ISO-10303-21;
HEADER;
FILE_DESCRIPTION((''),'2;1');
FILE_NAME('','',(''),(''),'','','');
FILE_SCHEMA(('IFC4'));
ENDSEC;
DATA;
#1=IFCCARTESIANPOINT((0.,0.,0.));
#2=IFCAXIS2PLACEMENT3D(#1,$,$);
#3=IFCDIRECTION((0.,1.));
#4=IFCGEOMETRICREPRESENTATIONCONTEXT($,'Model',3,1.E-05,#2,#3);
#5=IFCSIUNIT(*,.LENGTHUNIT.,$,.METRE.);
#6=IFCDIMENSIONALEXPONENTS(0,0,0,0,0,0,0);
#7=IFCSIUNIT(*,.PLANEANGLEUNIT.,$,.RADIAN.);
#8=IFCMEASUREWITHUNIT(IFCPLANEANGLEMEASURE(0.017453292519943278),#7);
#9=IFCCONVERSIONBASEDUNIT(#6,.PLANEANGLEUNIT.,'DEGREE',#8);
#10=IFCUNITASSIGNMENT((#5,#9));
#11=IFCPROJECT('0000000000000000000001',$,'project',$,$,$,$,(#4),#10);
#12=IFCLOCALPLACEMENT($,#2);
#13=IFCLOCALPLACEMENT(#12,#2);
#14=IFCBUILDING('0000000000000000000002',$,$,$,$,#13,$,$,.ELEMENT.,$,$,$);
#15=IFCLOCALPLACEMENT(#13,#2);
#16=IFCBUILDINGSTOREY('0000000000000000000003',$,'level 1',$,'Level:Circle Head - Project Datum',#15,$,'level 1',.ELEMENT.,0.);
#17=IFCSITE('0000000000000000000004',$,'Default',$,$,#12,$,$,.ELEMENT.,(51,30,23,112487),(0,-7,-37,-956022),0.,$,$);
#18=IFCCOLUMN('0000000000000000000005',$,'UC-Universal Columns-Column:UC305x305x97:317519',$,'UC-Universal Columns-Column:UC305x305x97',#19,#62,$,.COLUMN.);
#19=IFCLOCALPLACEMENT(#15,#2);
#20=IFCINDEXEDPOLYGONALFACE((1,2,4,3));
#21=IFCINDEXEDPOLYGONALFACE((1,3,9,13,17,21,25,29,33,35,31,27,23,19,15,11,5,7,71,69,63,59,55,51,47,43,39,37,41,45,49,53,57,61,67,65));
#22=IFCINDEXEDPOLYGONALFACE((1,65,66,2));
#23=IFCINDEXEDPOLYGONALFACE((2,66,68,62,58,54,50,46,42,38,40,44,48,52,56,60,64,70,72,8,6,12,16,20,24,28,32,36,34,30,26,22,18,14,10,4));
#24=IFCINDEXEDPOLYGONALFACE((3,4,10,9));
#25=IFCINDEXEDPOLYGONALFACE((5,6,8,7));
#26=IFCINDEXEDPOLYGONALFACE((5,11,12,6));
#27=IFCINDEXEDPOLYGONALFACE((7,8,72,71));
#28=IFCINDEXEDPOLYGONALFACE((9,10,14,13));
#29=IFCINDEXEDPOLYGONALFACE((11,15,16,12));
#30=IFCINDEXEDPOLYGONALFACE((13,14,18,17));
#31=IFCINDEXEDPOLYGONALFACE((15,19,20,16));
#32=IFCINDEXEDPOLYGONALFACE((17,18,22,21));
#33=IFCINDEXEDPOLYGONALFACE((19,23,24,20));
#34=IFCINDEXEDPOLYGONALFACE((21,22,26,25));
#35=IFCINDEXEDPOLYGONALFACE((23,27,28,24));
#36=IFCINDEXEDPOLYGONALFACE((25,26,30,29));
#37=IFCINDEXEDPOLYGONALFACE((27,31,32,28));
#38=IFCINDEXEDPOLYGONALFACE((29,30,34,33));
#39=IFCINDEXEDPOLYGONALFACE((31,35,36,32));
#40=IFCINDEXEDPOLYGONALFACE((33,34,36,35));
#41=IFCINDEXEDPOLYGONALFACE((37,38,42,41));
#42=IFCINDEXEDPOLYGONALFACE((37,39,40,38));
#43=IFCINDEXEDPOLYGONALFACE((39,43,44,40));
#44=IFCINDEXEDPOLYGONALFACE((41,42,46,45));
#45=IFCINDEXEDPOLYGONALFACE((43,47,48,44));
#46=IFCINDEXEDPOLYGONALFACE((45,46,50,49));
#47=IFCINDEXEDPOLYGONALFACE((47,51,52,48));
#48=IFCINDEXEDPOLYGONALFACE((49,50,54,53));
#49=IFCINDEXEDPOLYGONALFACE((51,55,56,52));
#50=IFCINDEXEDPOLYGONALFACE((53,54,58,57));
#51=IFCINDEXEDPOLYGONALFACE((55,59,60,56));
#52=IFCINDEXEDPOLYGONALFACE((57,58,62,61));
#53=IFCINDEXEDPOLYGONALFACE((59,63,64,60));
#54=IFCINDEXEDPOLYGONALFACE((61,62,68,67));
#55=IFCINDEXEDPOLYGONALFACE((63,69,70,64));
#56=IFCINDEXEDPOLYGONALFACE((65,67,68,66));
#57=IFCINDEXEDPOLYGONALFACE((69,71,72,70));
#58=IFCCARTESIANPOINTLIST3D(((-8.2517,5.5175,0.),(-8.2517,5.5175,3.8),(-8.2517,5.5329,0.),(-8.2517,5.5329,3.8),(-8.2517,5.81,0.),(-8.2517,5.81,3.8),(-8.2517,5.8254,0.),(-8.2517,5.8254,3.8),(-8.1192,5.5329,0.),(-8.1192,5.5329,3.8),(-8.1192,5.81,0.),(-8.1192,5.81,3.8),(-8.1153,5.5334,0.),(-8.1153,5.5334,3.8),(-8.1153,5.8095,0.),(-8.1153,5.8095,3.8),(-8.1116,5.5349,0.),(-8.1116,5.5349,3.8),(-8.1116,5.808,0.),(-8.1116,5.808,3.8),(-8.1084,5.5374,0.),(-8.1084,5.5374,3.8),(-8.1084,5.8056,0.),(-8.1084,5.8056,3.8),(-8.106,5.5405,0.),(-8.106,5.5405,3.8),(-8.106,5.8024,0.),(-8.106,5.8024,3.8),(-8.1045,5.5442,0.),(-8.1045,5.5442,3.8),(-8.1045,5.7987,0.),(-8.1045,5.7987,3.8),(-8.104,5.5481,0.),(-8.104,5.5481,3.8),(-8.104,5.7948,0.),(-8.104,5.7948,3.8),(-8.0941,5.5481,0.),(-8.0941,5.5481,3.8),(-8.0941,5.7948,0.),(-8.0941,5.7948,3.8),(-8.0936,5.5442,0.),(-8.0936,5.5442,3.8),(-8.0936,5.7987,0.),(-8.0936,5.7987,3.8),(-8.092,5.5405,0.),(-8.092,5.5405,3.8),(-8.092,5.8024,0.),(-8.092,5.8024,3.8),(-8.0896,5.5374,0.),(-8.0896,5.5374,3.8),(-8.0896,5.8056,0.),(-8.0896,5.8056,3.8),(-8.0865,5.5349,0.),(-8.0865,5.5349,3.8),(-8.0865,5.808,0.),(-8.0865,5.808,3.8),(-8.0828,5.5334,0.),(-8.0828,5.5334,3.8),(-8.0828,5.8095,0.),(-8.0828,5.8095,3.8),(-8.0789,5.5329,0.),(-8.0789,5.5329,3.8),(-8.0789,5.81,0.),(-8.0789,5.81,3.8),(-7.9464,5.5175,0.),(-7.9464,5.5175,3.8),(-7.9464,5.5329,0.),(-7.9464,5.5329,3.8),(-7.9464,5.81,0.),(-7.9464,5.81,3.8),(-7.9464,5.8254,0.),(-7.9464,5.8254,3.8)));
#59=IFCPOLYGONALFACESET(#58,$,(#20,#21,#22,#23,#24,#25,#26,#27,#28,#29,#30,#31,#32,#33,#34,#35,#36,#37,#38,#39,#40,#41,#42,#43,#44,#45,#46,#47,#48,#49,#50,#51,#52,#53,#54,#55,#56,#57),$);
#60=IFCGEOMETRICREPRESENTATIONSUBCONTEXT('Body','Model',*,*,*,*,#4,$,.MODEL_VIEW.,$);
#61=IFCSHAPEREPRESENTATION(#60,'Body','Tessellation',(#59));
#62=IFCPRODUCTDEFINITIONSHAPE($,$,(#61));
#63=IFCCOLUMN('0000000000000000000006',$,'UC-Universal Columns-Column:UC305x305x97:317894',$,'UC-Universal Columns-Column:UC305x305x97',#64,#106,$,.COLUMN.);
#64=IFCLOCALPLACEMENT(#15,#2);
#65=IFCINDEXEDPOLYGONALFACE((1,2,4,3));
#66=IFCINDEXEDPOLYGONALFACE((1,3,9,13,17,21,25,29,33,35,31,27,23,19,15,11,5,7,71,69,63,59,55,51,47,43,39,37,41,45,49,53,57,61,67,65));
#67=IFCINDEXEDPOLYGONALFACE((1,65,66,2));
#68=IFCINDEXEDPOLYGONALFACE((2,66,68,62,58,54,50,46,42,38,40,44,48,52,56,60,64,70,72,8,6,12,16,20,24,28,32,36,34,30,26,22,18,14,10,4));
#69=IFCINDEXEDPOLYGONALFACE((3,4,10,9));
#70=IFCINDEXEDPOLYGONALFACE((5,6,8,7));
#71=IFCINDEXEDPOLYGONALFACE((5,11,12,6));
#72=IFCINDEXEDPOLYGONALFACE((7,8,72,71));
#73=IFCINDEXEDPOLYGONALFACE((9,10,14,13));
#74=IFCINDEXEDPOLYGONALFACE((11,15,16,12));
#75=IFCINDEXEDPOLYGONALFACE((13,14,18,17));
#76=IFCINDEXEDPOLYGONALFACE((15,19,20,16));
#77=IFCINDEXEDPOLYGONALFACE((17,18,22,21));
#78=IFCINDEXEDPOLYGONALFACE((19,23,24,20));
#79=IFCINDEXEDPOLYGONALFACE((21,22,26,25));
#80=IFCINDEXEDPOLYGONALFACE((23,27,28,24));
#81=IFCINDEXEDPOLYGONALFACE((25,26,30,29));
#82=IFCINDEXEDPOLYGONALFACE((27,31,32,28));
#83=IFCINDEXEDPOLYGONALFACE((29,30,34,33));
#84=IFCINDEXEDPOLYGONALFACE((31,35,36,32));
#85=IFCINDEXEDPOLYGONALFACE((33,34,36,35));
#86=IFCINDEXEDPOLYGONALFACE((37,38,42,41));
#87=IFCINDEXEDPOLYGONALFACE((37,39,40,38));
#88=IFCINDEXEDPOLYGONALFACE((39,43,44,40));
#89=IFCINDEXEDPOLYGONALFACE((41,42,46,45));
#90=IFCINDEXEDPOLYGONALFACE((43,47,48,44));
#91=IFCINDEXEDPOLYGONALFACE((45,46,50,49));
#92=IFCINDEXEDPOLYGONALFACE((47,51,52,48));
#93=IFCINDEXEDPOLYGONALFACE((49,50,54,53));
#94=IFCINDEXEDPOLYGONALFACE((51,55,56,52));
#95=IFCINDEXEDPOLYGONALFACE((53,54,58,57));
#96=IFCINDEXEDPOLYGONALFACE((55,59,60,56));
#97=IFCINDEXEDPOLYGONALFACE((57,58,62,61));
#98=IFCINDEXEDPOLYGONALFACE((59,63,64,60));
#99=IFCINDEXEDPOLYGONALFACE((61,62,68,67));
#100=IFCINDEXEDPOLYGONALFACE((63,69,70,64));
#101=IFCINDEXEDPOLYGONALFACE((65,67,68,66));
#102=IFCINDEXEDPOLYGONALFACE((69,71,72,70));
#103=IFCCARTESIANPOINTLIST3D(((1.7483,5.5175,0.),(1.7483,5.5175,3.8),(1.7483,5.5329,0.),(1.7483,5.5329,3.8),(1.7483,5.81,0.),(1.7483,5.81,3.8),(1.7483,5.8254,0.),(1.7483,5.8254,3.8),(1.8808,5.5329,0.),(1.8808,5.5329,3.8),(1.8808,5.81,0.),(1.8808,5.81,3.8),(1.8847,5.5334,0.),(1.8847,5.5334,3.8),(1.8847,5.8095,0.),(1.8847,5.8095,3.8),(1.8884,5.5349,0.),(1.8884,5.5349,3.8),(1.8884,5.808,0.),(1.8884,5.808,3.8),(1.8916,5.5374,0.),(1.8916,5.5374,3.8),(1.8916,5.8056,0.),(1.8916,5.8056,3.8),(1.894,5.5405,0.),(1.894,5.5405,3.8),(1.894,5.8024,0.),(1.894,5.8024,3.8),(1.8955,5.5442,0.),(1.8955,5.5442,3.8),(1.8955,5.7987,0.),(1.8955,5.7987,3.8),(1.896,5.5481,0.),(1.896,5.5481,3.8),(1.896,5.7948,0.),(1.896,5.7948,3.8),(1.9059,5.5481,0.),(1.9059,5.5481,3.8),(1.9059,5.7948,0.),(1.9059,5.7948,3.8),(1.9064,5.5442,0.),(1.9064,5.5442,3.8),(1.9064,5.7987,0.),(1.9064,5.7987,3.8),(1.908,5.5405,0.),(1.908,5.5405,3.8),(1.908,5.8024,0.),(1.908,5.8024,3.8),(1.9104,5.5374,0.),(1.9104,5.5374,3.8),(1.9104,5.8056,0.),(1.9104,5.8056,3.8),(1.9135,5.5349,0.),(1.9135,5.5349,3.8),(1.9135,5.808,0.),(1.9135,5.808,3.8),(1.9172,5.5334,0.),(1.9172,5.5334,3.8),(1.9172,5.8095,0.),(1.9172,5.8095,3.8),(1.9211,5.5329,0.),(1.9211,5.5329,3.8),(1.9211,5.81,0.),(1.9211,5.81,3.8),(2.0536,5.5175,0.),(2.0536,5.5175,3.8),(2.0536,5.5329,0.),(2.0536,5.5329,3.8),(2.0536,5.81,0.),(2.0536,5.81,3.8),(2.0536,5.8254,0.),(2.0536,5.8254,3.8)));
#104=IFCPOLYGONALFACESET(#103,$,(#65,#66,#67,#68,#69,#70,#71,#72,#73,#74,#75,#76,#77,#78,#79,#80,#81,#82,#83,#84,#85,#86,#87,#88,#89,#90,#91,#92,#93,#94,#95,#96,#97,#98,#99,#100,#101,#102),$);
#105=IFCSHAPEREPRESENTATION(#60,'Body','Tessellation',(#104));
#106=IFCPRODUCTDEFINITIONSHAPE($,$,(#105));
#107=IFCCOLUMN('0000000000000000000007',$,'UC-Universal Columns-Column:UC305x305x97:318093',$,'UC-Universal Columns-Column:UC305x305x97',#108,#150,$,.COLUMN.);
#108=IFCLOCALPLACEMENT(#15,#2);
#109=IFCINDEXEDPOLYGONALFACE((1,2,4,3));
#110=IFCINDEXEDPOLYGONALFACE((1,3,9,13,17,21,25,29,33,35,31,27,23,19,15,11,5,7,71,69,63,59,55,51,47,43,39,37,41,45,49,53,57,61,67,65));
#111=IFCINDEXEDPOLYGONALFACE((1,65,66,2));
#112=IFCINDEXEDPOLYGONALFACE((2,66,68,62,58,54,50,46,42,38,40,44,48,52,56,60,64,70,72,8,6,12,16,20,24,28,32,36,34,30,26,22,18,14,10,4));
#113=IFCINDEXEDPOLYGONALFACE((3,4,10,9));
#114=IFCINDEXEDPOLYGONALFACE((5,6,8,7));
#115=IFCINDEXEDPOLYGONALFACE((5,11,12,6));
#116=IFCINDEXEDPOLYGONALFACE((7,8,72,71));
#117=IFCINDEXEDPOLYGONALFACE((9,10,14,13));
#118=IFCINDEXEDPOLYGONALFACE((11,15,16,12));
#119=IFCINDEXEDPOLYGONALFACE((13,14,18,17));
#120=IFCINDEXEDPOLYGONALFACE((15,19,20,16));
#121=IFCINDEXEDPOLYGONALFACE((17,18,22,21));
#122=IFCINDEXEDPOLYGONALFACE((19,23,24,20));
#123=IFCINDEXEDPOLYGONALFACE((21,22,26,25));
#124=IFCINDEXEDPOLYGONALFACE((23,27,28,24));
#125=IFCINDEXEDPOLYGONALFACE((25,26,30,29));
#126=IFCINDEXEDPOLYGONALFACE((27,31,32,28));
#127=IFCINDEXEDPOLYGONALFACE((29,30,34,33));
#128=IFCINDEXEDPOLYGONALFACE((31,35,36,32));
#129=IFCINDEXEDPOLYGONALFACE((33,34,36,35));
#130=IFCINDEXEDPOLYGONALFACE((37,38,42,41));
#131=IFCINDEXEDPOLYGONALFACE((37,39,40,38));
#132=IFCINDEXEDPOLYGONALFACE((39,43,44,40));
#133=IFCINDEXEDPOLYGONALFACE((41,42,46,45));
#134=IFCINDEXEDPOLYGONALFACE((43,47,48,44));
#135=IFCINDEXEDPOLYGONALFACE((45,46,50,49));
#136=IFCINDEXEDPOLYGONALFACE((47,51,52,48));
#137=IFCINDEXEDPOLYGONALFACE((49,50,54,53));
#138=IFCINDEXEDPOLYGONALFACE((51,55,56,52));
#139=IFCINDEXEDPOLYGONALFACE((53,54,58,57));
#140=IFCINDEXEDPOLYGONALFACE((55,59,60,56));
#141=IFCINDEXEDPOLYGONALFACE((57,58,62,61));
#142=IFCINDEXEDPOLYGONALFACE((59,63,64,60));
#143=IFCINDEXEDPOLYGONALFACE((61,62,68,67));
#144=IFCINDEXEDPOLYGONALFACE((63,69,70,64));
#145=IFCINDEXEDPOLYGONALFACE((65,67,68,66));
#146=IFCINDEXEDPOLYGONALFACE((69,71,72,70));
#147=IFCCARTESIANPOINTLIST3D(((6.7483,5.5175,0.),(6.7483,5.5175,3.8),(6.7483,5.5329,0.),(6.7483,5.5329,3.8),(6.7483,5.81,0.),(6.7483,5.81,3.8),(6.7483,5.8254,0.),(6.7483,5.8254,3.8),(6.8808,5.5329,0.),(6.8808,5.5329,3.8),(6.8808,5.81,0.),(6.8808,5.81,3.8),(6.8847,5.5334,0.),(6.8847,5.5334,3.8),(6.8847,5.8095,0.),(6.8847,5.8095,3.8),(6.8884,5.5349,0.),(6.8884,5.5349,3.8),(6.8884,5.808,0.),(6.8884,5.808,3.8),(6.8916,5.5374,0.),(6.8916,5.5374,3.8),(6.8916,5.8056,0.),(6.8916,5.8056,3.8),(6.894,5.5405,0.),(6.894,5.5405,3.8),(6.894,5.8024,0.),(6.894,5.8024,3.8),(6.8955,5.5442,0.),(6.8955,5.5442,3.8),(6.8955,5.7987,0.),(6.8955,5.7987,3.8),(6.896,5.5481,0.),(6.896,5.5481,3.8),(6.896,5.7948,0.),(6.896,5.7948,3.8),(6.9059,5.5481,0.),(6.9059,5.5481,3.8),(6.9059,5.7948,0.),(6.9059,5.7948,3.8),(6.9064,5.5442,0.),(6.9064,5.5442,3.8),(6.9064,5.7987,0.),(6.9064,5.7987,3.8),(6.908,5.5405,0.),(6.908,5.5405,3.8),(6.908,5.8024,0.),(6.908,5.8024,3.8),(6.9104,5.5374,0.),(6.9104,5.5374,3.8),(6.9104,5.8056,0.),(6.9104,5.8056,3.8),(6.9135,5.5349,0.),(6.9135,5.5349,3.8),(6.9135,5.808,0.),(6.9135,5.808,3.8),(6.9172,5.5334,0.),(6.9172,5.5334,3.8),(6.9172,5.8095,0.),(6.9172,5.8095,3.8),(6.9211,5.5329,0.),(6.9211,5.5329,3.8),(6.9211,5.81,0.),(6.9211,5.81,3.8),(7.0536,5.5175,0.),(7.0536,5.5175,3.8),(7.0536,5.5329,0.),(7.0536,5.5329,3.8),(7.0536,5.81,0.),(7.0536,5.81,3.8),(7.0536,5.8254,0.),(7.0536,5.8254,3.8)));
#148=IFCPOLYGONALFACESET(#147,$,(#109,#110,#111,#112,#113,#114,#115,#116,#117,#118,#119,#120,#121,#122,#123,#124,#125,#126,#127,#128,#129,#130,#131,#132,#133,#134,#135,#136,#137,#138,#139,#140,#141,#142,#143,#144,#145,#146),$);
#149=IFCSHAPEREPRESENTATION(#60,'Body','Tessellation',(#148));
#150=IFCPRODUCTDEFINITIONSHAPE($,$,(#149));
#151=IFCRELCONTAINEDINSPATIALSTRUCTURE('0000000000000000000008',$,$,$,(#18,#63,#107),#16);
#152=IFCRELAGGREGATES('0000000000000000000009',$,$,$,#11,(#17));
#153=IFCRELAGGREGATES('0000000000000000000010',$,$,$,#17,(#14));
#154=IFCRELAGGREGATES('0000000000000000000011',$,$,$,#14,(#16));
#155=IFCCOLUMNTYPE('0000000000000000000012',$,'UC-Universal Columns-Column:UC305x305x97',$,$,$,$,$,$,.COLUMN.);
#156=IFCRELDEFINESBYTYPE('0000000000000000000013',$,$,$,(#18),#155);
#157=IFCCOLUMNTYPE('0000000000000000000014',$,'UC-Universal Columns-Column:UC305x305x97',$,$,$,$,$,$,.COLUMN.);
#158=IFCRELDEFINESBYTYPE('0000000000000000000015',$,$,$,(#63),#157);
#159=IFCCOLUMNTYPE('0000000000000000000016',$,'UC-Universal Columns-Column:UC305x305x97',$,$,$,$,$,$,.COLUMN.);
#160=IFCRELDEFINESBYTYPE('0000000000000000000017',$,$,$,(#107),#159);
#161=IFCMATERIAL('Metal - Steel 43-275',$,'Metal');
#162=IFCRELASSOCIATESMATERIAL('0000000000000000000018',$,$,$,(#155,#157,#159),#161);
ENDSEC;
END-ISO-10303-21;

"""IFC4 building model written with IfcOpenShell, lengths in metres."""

from ifc_helpers import new_model, entity, si_unit, converted_unit, direction, frame, frame_2d, origin, place, context, subcontext, project, spatial, i_section, extrude, source, transform, mapped, material, material_profile, profile_set, type_object, type_shapes, element, save


model = new_model("IFC4")

# Units and contexts
model_context = context("Model", 3, precision=1e-05, world=origin(), true_north=direction((0.0, 1.0)))
body_context = subcontext(model_context, "Body", "Model", "MODEL_VIEW")
ifc_project = project(units=[si_unit("LENGTHUNIT", "METRE"), converted_unit("PLANEANGLEUNIT", "DEGREE", entity("IfcPlaneAngleMeasure", 0.017453292519943278), si_unit("PLANEANGLEUNIT", "RADIAN"), dimensions=[0, 0, 0, 0, 0, 0, 0])], contexts=[model_context])

# Site, building, storey
site_placement = place(None, origin())
site = spatial("IfcSite", under=ifc_project, at=site_placement, Name="Default", CompositionType="ELEMENT", RefLatitude=(51, 30, 23, 112487), RefLongitude=(0, -7, -37, -956022), RefElevation=0.0)
building_placement = place(site_placement, origin())
building = spatial("IfcBuilding", under=site, at=building_placement, CompositionType="ELEMENT")
storey_placement = place(building_placement, origin())
storey = spatial("IfcBuildingStorey", under=building, at=storey_placement, Name="level 1", ObjectType="Level:Circle Head - Project Datum", LongName="level 1", CompositionType="ELEMENT", Elevation=0.0)

# Columns
ifc_material_1 = material(Name="Metal - Steel 43-275", Category="Metal")
ifc_material_profile = material_profile(ifc_material_1, i_section(OverallWidth=0.3053, OverallDepth=0.3079, WebThickness=0.0099, FlangeThickness=0.0154, FilletRadius=0.0152, at=frame_2d((0.0, 0.0), x_axis=(1.0, 0.0))), Name="UC305x305x97")
ifc_profile_set = profile_set([ifc_material_profile], Name="UC305x305x97")
column_type_1 = type_object("IfcColumnType", Name="UC-Universal Columns-Column:UC305x305x97", PredefinedType="COLUMN", material=ifc_profile_set)
shared_shape_1 = source(origin(), body_context, "Body", "SweptSolid", [
    extrude(i_section(OverallWidth=0.3053, OverallDepth=0.3079, WebThickness=0.0099, FlangeThickness=0.0154, FilletRadius=0.0152, at=frame_2d((0.0, 0.0), x_axis=(1.0, 0.0))), frame((-8.099, 5.6715, 0.0), z_axis=(0.0, 0.0, 1.0), x_axis=(-1.0, 0.0, 0.0)), (0.0, 0.0, 1.0), 3.8),
])
type_shapes(column_type_1, [shared_shape_1])
column_1_placement = place(storey_placement, origin())
element("IfcColumn", 1, at=column_1_placement, inside=storey, type_object=column_type_1, Name="UC-Universal Columns-Column:UC305x305x97:317519", ObjectType="UC-Universal Columns-Column:UC305x305x97", PredefinedType="COLUMN", context=body_context, shape_type="MappedRepresentation", body=[
    mapped(shared_shape_1, transform((0.0, 0.0, 0.0), scale=1.0)),
])
column_type_2 = type_object("IfcColumnType", Name="UC-Universal Columns-Column:UC305x305x97", PredefinedType="COLUMN", material=ifc_profile_set)
shared_shape_2 = source(origin(), body_context, "Body", "SweptSolid", [
    extrude(i_section(OverallWidth=0.3053, OverallDepth=0.3079, WebThickness=0.0099, FlangeThickness=0.0154, FilletRadius=0.0152, at=frame_2d((0.0, 0.0), x_axis=(1.0, 0.0))), frame((1.901, 5.6715, 0.0), z_axis=(0.0, 0.0, 1.0), x_axis=(-1.0, 0.0, 0.0)), (0.0, 0.0, 1.0), 3.8),
])
type_shapes(column_type_2, [shared_shape_2])
column_2_placement = place(storey_placement, origin())
element("IfcColumn", 2, at=column_2_placement, inside=storey, type_object=column_type_2, Name="UC-Universal Columns-Column:UC305x305x97:317894", ObjectType="UC-Universal Columns-Column:UC305x305x97", PredefinedType="COLUMN", context=body_context, shape_type="MappedRepresentation", body=[
    mapped(shared_shape_2, transform((0.0, 0.0, 0.0), scale=1.0)),
])
column_type_3 = type_object("IfcColumnType", Name="UC-Universal Columns-Column:UC305x305x97", PredefinedType="COLUMN", material=ifc_profile_set)
shared_shape_3 = source(origin(), body_context, "Body", "SweptSolid", [
    extrude(i_section(OverallWidth=0.3053, OverallDepth=0.3079, WebThickness=0.0099, FlangeThickness=0.0154, FilletRadius=0.0152, at=frame_2d((0.0, 0.0), x_axis=(1.0, 0.0))), frame((6.901, 5.6715, 0.0), z_axis=(0.0, 0.0, 1.0), x_axis=(-1.0, 0.0, 0.0)), (0.0, 0.0, 1.0), 3.8),
])
type_shapes(column_type_3, [shared_shape_3])
column_3_placement = place(storey_placement, origin())
element("IfcColumn", 3, at=column_3_placement, inside=storey, type_object=column_type_3, Name="UC-Universal Columns-Column:UC305x305x97:318093", ObjectType="UC-Universal Columns-Column:UC305x305x97", PredefinedType="COLUMN", context=body_context, shape_type="MappedRepresentation", body=[
    mapped(shared_shape_3, transform((0.0, 0.0, 0.0), scale=1.0)),
])

save(model, "model.ifc")
